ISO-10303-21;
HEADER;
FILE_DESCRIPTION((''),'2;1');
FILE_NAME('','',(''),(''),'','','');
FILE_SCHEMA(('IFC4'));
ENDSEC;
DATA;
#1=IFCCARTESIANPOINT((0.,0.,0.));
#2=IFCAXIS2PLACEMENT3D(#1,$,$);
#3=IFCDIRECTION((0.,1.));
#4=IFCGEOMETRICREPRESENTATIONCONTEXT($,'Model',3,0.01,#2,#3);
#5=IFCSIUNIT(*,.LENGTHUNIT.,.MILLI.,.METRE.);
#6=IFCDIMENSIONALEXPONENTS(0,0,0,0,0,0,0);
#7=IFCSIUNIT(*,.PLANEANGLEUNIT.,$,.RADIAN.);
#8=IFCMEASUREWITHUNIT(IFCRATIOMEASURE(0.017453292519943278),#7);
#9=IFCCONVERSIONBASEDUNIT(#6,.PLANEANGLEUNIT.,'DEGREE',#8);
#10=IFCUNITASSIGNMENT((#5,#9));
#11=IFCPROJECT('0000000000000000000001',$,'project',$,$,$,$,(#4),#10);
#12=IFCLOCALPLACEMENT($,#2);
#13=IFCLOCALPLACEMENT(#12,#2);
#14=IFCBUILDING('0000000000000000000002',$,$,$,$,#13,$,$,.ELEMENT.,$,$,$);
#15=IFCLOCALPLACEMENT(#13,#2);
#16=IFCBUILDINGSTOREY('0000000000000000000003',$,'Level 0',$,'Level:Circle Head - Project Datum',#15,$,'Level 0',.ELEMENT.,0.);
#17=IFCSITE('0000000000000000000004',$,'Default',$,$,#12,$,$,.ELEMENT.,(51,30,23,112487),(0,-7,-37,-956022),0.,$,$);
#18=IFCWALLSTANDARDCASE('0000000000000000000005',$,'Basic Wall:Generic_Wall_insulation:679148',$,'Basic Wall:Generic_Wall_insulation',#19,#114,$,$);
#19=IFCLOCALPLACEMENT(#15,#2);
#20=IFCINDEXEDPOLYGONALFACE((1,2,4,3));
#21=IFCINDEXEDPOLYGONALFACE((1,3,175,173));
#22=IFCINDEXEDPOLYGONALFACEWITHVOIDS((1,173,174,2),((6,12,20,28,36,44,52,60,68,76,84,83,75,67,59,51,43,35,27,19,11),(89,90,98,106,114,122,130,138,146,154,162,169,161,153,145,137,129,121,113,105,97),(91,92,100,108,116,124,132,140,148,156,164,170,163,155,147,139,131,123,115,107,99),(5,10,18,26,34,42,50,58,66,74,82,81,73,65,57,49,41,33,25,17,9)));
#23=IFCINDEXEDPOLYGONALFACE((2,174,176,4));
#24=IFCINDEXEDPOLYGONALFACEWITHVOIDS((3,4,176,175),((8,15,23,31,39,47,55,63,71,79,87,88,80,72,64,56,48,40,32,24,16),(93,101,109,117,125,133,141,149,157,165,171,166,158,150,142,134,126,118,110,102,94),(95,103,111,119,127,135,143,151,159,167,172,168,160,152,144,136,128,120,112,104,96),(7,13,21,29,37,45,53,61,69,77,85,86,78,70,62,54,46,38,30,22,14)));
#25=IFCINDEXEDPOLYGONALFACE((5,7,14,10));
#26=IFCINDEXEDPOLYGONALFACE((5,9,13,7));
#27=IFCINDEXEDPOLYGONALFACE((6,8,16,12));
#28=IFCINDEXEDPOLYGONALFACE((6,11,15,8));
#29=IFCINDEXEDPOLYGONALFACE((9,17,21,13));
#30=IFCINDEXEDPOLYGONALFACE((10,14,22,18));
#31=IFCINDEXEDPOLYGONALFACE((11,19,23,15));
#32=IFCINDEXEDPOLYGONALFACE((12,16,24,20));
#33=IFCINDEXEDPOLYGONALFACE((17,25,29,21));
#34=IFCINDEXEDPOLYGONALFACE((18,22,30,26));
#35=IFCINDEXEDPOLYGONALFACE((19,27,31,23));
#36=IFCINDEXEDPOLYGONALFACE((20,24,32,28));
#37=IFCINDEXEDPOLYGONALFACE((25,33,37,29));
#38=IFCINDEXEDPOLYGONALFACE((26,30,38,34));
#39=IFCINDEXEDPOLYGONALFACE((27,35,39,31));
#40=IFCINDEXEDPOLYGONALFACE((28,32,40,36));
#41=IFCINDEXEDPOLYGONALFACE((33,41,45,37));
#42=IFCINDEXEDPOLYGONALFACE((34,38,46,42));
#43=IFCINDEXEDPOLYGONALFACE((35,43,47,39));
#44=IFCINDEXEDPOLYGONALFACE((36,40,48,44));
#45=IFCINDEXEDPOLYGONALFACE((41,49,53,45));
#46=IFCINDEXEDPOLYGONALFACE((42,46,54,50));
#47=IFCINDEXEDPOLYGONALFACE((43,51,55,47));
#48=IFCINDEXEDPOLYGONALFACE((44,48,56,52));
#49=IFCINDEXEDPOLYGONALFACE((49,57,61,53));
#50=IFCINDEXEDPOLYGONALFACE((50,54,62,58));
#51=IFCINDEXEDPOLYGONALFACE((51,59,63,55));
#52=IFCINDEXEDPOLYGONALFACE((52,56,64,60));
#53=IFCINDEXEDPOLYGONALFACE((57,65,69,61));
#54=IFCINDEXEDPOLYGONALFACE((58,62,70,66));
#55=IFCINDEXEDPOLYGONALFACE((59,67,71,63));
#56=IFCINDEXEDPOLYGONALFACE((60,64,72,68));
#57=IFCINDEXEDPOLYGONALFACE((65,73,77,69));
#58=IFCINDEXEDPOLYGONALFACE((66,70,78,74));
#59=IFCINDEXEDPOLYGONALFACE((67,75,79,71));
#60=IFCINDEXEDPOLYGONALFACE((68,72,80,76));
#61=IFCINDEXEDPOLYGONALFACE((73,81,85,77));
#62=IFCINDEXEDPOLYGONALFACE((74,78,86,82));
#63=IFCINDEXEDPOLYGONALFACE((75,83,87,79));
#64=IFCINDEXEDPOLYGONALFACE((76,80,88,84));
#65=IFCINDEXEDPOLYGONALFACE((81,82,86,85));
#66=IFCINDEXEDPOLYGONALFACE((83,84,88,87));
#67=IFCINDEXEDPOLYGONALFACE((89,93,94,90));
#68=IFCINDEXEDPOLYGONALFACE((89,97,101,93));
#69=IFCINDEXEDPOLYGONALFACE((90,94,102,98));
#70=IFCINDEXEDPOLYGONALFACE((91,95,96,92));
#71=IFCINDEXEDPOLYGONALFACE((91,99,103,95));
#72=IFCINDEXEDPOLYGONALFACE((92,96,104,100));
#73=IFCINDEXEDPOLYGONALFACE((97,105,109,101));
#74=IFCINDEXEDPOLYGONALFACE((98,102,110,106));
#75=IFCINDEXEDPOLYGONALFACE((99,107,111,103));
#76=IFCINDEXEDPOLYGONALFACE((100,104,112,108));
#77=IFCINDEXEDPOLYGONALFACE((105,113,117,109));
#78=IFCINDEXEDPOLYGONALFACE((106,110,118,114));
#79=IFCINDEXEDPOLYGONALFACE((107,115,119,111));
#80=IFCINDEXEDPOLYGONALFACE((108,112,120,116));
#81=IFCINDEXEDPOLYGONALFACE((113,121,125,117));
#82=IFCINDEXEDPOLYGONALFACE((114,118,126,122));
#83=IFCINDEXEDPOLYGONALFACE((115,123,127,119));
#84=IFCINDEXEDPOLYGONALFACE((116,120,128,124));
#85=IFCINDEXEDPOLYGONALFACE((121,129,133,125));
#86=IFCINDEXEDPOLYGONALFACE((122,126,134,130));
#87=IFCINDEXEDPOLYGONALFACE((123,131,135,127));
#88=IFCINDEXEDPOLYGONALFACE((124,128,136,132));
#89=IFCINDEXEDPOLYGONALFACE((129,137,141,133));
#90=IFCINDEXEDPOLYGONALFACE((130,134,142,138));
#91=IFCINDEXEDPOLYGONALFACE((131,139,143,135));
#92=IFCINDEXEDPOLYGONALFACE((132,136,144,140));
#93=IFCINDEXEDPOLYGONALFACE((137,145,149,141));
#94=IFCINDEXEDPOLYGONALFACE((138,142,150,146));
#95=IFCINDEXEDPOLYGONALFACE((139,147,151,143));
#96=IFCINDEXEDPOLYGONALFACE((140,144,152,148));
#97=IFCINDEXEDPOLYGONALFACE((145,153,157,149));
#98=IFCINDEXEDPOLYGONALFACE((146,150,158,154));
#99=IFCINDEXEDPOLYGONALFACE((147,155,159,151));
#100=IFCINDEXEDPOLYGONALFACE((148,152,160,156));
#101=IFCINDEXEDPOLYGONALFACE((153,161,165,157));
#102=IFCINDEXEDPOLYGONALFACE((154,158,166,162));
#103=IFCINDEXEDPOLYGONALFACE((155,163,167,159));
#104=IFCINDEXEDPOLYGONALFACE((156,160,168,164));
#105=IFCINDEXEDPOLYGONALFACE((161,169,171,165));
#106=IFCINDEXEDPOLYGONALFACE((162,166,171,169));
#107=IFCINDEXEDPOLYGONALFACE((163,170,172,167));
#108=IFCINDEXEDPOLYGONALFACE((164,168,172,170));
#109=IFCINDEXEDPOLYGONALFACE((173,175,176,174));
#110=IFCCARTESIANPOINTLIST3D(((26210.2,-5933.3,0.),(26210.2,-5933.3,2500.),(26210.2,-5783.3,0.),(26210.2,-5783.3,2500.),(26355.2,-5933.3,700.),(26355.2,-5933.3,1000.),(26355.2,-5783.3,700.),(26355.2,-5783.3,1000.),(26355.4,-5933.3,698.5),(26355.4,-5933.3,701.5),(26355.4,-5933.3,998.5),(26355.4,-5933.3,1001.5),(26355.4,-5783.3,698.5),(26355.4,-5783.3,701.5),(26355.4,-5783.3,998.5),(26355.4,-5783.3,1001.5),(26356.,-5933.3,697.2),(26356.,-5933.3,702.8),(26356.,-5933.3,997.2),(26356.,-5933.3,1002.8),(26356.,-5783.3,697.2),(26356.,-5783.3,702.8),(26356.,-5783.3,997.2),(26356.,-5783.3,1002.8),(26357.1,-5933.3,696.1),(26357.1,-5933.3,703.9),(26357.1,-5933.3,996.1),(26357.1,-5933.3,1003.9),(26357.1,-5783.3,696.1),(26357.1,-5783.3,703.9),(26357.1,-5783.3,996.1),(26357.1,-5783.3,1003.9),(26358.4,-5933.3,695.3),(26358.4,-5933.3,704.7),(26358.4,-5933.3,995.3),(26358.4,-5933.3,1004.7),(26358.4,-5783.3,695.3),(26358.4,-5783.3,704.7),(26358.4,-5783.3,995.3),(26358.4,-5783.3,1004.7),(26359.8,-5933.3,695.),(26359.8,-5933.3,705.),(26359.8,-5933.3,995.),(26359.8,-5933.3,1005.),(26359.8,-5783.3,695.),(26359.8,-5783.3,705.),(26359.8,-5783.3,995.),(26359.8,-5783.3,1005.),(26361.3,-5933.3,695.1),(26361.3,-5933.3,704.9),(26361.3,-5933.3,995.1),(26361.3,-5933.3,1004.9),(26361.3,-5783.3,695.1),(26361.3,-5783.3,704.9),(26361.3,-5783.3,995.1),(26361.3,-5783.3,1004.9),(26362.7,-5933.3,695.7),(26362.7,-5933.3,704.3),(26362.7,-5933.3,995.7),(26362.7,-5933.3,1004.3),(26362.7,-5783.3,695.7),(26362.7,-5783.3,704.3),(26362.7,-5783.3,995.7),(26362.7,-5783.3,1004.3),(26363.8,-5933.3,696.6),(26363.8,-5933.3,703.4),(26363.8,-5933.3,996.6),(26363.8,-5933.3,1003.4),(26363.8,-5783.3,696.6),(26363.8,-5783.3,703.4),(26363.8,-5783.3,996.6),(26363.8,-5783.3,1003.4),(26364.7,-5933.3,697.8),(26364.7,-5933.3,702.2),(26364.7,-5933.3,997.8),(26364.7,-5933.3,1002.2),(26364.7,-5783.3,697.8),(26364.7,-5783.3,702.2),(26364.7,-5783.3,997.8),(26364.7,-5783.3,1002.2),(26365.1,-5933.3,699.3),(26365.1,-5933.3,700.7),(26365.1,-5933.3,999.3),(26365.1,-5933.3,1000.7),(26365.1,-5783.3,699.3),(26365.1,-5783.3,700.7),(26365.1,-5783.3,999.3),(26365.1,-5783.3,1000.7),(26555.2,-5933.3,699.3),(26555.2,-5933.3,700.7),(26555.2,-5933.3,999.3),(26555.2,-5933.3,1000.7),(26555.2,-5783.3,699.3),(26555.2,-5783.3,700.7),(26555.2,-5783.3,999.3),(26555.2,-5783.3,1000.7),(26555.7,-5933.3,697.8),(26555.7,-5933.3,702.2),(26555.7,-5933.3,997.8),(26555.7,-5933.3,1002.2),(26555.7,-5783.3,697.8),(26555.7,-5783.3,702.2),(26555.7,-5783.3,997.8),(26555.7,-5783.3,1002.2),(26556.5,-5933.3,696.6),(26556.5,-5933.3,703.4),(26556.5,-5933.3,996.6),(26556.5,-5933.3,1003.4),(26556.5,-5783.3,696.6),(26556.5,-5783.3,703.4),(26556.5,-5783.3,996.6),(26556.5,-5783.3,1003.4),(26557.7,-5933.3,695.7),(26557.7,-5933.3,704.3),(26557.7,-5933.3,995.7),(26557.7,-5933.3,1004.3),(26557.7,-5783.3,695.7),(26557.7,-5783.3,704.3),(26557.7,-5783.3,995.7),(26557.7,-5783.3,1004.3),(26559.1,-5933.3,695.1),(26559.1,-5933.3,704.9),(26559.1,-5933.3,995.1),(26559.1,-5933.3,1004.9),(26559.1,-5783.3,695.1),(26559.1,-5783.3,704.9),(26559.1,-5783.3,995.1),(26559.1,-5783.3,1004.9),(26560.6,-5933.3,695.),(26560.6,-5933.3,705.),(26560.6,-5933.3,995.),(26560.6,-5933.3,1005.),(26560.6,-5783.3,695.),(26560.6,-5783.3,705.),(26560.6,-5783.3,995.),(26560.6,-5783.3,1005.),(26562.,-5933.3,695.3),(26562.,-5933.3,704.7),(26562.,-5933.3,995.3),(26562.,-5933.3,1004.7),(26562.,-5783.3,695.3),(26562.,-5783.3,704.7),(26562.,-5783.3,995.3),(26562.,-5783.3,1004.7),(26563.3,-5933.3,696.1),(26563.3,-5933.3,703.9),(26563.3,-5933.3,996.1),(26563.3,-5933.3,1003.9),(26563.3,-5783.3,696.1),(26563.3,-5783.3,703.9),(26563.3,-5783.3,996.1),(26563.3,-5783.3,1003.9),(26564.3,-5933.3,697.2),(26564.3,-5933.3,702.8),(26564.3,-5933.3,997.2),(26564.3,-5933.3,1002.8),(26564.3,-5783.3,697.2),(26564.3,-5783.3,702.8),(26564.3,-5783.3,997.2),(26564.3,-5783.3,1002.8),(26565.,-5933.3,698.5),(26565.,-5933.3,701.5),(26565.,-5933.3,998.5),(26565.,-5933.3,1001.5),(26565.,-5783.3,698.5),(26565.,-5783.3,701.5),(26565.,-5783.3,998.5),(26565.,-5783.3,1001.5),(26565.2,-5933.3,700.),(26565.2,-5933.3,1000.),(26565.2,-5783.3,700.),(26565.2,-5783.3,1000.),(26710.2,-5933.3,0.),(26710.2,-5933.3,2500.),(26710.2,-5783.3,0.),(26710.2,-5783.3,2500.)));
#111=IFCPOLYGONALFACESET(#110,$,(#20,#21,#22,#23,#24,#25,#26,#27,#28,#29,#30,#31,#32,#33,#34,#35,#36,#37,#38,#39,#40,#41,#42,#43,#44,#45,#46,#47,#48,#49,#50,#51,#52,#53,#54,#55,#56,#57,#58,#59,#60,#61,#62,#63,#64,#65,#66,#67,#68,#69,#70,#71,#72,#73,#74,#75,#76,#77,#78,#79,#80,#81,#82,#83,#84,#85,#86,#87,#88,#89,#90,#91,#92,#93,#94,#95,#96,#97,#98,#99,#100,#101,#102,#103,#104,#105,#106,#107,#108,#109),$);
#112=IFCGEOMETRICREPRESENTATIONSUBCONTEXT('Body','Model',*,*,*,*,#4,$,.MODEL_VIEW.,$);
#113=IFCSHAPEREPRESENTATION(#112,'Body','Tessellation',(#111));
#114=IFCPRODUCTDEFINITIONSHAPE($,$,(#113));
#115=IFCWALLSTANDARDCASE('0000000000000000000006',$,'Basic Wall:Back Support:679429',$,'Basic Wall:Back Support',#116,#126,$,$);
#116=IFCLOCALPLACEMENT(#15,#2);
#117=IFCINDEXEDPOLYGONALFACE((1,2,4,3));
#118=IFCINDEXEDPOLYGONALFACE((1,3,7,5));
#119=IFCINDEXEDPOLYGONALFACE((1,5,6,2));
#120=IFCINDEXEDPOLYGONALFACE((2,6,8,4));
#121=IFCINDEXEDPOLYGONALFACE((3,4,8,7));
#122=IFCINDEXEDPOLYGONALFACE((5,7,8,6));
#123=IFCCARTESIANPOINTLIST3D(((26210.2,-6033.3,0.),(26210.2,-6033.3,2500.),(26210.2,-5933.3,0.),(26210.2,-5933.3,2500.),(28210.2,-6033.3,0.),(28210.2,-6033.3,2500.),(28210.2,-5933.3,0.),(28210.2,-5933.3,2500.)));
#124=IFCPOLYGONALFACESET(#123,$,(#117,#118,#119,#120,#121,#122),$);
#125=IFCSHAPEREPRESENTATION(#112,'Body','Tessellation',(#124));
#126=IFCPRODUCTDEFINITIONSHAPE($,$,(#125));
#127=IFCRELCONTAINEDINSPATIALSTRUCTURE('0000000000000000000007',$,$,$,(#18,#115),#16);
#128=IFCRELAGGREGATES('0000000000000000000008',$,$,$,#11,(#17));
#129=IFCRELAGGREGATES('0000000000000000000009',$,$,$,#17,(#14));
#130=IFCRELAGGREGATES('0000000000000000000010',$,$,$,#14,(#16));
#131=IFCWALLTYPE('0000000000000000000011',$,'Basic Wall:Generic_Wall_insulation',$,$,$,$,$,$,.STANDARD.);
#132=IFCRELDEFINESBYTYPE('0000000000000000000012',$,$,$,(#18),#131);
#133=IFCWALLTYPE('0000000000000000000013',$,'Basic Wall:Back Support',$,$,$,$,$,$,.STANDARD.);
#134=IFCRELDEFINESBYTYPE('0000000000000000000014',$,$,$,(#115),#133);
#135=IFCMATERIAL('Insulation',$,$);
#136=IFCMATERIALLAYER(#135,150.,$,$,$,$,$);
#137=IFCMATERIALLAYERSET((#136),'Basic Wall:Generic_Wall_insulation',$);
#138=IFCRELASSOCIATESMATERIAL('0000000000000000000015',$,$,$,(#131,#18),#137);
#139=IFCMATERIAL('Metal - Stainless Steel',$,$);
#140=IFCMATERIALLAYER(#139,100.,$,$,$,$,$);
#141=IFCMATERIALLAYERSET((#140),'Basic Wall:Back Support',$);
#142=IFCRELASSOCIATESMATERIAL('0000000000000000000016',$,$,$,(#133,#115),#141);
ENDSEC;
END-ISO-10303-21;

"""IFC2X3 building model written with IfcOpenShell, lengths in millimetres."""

from ifc_helpers import new_model, entity, si_unit, converted_unit, direction, frame, frame_2d, origin, origin_2d_with_axis, place, context, subcontext, project, spatial, rectangle, circle, extrude, material, layer, layer_set, layer_usage, type_object, element, save


model = new_model("IFC2X3")

# Units and contexts
model_context = context("Model", 3, precision=0.01, world=origin(), true_north=direction((0.0, 1.0)))
body_context = subcontext(model_context, "Body", "Model", "MODEL_VIEW")
ifc_project = project(units=[si_unit("LENGTHUNIT", "METRE", prefix="MILLI"), converted_unit("PLANEANGLEUNIT", "DEGREE", entity("IfcRatioMeasure", 0.017453292519943278), si_unit("PLANEANGLEUNIT", "RADIAN"), dimensions=[0, 0, 0, 0, 0, 0, 0])], contexts=[model_context])

# Site, building, storey
site_placement = place(None, origin())
site = spatial("IfcSite", under=ifc_project, at=site_placement, Name="Default", CompositionType="ELEMENT", RefLatitude=(51, 30, 23, 112487), RefLongitude=(0, -7, -37, -956022), RefElevation=0.0)
building_placement = place(site_placement, origin())
building = spatial("IfcBuilding", under=site, at=building_placement, CompositionType="ELEMENT")
storey_placement = place(building_placement, origin())
storey = spatial("IfcBuildingStorey", under=building, at=storey_placement, Name="Level 0", ObjectType="Level:Circle Head - Project Datum", LongName="Level 0", CompositionType="ELEMENT", Elevation=0.0)

# Wall, openings
ifc_material_1 = material(Name="Insulation")
ifc_layer_1 = layer(ifc_material_1, 150.0)
ifc_layer_set_1 = layer_set([ifc_layer_1], Name="Basic Wall:Generic_Wall_insulation")
ifc_layer_usage_1 = layer_usage(ifc_layer_set_1, "AXIS2", "NEGATIVE", 75.0)
wall_type_1 = type_object("IfcWallType", Name="Basic Wall:Generic_Wall_insulation", PredefinedType="STANDARD", material=ifc_layer_set_1)
wall_1_placement = place(storey_placement, frame((26710.2, -5858.3, 0.0), z_axis=(0.0, 0.0, 1.0), x_axis=(-1.0, 0.0, 0.0)))
wall_1 = element("IfcWallStandardCase", 1, at=wall_1_placement, inside=storey, type_object=wall_type_1, material=ifc_layer_usage_1, Name="Basic Wall:Generic_Wall_insulation:679148", ObjectType="Basic Wall:Generic_Wall_insulation", context=body_context, shape_type="SweptSolid", body=[
    extrude(rectangle(XDim=500.0, YDim=150.0, at=frame_2d((250.0, 0.0), x_axis=(-1.0, 0.0))), origin(), (0.0, 0.0, 1.0), 2500.0),
])
opening_1_placement = place(wall_1_placement, origin())
element("IfcOpeningElement", 2, at=opening_1_placement, cuts=wall_1, ObjectType="Opening", context=body_context, shape_type="SweptSolid", body=[
    extrude(circle(Radius=5.0, at=origin_2d_with_axis()), frame((150.0, -75.0, 700.0), z_axis=(0.0, 1.0, 0.0), x_axis=(-1.0, 0.0, 0.0)), (0.0, 0.0, 1.0), 200.0),
])
opening_2_placement = place(wall_1_placement, origin())
element("IfcOpeningElement", 3, at=opening_2_placement, cuts=wall_1, ObjectType="Opening", context=body_context, shape_type="SweptSolid", body=[
    extrude(circle(Radius=5.0, at=origin_2d_with_axis()), frame((150.0, -75.0, 1000.0), z_axis=(0.0, 1.0, 0.0), x_axis=(-1.0, 0.0, 0.0)), (0.0, 0.0, 1.0), 200.0),
])
opening_3_placement = place(wall_1_placement, origin())
element("IfcOpeningElement", 4, at=opening_3_placement, cuts=wall_1, ObjectType="Opening", context=body_context, shape_type="SweptSolid", body=[
    extrude(circle(Radius=5.0, at=origin_2d_with_axis()), frame((350.0, -75.0, 700.0), z_axis=(0.0, 1.0, 0.0), x_axis=(1.0, 0.0, 0.0)), (0.0, 0.0, 1.0), 200.0),
])
opening_4_placement = place(wall_1_placement, origin())
element("IfcOpeningElement", 5, at=opening_4_placement, cuts=wall_1, ObjectType="Opening", context=body_context, shape_type="SweptSolid", body=[
    extrude(circle(Radius=5.0, at=origin_2d_with_axis()), frame((350.0, -75.0, 1000.0), z_axis=(0.0, 1.0, 0.0), x_axis=(1.0, 0.0, 0.0)), (0.0, 0.0, 1.0), 200.0),
])

# Wall
ifc_material_2 = material(Name="Metal - Stainless Steel")
ifc_layer_2 = layer(ifc_material_2, 100.0)
ifc_layer_set_2 = layer_set([ifc_layer_2], Name="Basic Wall:Back Support")
ifc_layer_usage_2 = layer_usage(ifc_layer_set_2, "AXIS2", "NEGATIVE", 50.0)
wall_type_2 = type_object("IfcWallType", Name="Basic Wall:Back Support", PredefinedType="STANDARD", material=ifc_layer_set_2)
wall_2_placement = place(storey_placement, frame((28210.2, -5983.3, 0.0), z_axis=(0.0, 0.0, 1.0), x_axis=(-1.0, 0.0, 0.0)))
element("IfcWallStandardCase", 6, at=wall_2_placement, inside=storey, type_object=wall_type_2, material=ifc_layer_usage_2, Name="Basic Wall:Back Support:679429", ObjectType="Basic Wall:Back Support", context=body_context, shape_type="SweptSolid", body=[
    extrude(rectangle(XDim=2000.0, YDim=100.0, at=frame_2d((1000.0, 0.0), x_axis=(-1.0, 0.0))), origin(), (0.0, 0.0, 1.0), 2500.0),
])

save(model, "model.ifc")
